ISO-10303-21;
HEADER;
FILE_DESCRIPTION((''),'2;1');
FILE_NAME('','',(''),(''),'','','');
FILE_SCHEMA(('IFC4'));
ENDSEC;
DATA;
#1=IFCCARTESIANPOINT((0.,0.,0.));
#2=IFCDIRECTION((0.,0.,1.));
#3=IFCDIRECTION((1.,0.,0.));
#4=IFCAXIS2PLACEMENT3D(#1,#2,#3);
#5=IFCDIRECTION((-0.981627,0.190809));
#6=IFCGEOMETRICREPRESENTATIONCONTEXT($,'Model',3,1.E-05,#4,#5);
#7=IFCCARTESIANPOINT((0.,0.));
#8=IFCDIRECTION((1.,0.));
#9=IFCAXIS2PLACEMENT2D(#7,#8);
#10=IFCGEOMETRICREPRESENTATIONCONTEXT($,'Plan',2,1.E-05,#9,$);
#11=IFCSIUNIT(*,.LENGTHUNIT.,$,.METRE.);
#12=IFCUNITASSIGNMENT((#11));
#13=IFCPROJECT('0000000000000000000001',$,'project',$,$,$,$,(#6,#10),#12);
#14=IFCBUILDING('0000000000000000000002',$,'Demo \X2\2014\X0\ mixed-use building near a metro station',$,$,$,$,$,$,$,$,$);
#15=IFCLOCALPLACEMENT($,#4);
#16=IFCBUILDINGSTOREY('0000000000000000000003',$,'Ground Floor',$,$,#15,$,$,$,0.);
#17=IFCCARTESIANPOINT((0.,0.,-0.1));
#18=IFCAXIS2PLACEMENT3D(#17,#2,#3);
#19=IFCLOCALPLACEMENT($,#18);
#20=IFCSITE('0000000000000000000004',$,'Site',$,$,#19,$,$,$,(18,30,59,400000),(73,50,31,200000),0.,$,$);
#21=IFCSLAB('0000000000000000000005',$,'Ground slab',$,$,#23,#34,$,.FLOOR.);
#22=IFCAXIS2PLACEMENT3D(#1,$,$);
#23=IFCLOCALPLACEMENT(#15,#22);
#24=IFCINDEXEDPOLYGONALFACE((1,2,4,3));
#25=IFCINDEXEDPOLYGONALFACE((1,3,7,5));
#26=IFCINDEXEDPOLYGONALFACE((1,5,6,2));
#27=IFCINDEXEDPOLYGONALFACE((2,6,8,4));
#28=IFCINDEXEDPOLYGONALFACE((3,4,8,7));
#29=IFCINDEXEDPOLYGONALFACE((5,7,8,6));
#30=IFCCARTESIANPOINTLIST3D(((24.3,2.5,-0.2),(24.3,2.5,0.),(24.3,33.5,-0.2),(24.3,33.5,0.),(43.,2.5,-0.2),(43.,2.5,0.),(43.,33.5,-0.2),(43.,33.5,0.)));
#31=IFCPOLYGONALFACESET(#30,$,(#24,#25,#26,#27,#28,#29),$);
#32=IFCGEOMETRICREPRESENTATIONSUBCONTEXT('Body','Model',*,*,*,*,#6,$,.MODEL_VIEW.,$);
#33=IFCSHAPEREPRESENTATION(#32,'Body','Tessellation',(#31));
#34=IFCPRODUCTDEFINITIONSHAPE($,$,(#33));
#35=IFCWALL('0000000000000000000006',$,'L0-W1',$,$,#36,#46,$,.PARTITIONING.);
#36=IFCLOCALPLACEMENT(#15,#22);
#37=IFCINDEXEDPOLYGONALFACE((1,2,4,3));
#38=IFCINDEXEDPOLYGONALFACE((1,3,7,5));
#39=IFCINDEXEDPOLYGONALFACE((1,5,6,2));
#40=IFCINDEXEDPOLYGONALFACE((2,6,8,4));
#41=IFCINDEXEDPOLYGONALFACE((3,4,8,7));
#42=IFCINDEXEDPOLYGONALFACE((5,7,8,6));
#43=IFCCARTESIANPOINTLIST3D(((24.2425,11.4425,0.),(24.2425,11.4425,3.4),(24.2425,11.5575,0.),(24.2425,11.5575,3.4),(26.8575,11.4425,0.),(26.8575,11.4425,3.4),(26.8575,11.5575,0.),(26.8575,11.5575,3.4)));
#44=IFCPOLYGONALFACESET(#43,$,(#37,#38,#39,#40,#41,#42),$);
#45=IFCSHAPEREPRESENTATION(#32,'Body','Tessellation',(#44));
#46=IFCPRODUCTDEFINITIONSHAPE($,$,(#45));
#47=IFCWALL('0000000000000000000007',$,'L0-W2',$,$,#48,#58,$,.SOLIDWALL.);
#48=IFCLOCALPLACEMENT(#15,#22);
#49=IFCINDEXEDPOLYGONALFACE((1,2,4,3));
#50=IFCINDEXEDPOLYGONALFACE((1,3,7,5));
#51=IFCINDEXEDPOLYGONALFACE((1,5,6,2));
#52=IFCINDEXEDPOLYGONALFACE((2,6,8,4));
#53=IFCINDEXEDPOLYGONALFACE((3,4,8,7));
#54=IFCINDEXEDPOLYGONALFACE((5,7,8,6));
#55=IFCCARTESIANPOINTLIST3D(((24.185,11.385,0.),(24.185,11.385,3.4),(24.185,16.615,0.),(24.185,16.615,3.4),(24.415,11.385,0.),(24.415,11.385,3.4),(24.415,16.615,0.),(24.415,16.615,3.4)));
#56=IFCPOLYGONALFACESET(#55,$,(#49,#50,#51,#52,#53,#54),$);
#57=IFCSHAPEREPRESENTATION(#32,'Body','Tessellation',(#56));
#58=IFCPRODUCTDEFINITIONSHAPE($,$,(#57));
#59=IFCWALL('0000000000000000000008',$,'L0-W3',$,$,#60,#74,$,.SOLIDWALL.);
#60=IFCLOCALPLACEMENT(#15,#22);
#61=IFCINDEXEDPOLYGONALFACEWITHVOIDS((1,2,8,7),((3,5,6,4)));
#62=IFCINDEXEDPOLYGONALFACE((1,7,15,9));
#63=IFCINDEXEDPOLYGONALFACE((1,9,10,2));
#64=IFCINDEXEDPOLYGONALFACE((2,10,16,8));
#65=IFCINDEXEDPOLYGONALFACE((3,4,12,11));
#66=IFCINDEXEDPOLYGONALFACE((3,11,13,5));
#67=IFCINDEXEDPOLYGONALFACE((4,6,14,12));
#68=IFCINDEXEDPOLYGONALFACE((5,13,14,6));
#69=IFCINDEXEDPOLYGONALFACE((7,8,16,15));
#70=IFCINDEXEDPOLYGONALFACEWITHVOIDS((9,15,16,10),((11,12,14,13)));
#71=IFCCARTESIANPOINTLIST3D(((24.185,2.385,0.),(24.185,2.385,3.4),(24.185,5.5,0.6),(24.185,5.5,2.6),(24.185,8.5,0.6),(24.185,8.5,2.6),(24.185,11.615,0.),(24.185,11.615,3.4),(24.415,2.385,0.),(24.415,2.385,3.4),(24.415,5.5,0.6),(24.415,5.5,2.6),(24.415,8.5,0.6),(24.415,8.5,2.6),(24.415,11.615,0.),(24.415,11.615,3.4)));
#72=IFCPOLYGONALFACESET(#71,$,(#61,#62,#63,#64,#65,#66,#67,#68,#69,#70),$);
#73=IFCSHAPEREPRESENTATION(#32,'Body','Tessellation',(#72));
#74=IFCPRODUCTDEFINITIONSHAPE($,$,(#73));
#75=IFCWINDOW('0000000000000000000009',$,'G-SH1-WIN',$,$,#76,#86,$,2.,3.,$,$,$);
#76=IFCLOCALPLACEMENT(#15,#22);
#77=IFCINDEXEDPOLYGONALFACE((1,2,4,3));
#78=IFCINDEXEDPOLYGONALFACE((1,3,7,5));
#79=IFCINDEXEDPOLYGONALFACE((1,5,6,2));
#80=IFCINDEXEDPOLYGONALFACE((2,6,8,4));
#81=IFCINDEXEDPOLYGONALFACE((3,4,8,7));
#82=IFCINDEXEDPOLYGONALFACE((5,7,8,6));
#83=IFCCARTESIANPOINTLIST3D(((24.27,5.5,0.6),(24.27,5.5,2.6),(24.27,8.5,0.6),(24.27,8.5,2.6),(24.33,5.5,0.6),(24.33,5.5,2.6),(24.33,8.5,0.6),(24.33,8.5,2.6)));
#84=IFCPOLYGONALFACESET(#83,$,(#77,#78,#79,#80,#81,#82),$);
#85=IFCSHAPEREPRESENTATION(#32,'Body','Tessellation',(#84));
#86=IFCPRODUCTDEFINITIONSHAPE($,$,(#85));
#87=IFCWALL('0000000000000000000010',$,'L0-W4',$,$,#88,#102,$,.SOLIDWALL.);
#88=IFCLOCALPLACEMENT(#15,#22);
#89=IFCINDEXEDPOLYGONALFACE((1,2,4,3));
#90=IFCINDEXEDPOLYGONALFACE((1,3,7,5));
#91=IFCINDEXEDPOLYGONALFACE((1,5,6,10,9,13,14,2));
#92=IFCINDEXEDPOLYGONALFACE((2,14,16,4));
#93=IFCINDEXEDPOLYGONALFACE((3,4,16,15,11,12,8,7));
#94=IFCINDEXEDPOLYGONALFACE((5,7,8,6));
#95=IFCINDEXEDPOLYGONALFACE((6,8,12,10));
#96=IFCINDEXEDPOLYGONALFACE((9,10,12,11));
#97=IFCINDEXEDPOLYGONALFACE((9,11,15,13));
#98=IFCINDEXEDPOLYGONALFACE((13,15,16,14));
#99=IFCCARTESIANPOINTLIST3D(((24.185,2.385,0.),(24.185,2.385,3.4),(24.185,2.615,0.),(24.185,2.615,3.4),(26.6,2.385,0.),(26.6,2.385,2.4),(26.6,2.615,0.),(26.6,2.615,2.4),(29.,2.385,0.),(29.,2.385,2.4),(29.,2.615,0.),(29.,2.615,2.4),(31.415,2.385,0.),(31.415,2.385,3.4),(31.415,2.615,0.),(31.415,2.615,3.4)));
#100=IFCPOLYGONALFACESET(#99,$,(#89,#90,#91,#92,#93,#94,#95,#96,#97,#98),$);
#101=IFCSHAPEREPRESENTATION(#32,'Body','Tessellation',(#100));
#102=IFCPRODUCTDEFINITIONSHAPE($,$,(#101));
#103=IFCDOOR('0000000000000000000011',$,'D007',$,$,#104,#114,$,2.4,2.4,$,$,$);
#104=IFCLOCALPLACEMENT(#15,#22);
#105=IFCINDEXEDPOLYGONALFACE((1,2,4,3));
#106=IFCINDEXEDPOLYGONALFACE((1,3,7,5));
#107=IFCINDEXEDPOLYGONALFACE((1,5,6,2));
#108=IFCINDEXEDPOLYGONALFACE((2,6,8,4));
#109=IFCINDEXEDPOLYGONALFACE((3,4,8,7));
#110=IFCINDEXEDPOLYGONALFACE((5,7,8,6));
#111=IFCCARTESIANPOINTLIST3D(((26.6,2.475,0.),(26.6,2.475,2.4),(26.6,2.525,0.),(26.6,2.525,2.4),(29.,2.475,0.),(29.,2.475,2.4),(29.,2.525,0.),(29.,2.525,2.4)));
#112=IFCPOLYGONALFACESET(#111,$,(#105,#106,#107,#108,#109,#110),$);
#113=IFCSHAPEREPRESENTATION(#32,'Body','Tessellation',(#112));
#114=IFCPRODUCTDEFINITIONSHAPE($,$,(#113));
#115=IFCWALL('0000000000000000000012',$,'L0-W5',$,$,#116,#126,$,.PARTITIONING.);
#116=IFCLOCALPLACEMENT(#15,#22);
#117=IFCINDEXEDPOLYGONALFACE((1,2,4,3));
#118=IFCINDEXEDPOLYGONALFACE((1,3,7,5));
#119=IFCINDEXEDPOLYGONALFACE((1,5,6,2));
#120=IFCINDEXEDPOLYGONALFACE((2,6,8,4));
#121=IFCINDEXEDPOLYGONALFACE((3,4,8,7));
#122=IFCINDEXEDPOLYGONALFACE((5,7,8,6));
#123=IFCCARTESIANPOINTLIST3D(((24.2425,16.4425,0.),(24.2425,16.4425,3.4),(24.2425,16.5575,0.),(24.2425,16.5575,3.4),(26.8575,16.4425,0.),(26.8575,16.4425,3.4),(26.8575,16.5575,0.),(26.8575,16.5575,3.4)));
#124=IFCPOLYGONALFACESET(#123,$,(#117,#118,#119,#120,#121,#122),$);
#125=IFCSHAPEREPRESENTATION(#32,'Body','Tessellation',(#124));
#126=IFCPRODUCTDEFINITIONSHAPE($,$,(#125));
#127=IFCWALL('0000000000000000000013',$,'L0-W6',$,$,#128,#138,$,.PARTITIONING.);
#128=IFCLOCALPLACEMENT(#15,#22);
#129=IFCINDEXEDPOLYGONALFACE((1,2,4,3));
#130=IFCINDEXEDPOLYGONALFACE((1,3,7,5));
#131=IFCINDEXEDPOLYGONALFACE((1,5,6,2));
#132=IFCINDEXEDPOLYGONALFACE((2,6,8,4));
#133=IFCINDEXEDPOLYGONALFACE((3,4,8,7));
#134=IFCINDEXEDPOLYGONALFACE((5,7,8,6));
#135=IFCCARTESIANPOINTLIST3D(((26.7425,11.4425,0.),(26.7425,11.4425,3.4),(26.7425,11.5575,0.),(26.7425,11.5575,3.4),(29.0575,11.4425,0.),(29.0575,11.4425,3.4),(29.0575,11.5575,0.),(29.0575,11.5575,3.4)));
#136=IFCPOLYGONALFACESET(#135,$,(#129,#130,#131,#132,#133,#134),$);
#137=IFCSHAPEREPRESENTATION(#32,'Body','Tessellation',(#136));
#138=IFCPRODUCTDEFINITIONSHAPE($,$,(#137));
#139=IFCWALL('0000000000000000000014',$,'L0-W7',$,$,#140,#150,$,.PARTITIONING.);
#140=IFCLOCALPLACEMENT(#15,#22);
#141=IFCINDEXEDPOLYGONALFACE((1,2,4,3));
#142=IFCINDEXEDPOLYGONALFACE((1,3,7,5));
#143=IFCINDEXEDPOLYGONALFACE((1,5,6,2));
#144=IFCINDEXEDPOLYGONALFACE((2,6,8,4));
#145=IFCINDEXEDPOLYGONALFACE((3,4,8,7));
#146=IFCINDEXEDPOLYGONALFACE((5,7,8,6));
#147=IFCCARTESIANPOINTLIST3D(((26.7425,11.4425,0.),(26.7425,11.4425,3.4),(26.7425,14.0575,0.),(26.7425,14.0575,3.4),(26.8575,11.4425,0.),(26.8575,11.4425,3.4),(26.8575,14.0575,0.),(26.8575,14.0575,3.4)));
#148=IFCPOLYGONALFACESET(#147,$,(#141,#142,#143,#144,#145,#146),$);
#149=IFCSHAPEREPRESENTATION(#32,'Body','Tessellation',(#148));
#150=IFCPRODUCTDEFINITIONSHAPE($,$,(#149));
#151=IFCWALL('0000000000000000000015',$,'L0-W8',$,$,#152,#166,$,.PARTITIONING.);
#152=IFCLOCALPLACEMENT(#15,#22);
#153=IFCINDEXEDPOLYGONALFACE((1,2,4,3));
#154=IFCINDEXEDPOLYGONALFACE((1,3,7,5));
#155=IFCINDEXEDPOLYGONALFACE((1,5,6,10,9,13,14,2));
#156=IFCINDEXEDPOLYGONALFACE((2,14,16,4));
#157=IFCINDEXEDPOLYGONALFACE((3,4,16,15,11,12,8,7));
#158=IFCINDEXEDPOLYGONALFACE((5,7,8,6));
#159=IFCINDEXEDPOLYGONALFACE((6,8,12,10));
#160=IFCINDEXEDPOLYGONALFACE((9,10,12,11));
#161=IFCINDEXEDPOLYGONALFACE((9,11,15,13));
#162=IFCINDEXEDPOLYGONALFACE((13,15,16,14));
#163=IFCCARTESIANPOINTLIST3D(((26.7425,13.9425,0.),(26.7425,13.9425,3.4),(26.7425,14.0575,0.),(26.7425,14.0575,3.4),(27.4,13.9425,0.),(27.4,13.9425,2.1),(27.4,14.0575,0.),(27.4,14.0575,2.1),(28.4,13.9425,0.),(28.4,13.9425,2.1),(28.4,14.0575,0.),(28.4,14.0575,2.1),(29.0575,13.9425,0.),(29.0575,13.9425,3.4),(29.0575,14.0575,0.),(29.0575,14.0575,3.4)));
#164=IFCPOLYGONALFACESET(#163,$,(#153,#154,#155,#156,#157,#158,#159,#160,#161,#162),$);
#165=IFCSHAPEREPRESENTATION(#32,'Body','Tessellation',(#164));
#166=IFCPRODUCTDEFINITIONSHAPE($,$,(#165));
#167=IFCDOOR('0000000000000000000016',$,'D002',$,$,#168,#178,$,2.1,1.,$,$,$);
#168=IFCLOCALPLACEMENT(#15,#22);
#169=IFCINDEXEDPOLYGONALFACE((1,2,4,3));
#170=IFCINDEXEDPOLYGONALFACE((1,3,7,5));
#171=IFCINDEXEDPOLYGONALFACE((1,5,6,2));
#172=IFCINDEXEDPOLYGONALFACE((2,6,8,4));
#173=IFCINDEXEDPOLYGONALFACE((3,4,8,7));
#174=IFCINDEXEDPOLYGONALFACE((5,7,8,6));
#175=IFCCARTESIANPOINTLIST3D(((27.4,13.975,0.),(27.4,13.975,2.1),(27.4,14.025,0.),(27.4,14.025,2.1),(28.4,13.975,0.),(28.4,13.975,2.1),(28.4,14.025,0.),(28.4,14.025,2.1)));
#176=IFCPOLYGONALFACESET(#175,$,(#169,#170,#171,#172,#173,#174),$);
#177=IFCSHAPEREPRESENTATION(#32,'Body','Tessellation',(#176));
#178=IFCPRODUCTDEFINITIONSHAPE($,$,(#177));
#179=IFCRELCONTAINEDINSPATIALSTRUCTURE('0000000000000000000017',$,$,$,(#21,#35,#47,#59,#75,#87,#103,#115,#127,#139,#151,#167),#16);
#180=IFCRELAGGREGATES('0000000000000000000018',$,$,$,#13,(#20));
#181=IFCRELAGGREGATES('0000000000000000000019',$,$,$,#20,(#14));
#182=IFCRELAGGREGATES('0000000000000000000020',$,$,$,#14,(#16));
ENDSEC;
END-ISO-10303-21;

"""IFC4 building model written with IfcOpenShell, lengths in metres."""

from ifc_helpers import new_model, si_unit, direction, frame, origin_with_axes, origin_2d_with_axis, place, context, subcontext, project, spatial, line, indexed_curve, outline, extrude, element, fill, save


model = new_model("IFC4")

# Units and contexts
model_context = context("Model", 3, precision=1e-05, world=origin_with_axes(), true_north=direction((-0.981627, 0.190809)))
plan_context = context("Plan", 2, precision=1e-05, world=origin_2d_with_axis())
body_context = subcontext(model_context, "Body", "Model", "MODEL_VIEW")
ifc_project = project(units=[si_unit("LENGTHUNIT", "METRE")], contexts=[model_context, plan_context])

# Site, building, storey
site_placement = place(None, frame((0.0, 0.0, -0.1), z_axis=(0.0, 0.0, 1.0), x_axis=(1.0, 0.0, 0.0)))
site = spatial("IfcSite", under=ifc_project, at=site_placement, Name="Site", RefLatitude=(18, 30, 59, 400000), RefLongitude=(73, 50, 31, 200000), RefElevation=0.0)
building = spatial("IfcBuilding", under=site, Name="Demo — mixed-use building near a metro station")
storey_placement = place(None, origin_with_axes())
storey = spatial("IfcBuildingStorey", under=building, at=storey_placement, Name="Ground Floor", Elevation=0.0)

# Slab
slab_placement = place(storey_placement, frame((0.0, 0.0, -0.2), z_axis=(0.0, 0.0, 1.0), x_axis=(1.0, 0.0, 0.0)))
element("IfcSlab", 1, at=slab_placement, inside=storey, Name="Ground slab", PredefinedType="FLOOR", context=body_context, shape_type="SweptSolid", body=[
    extrude(outline(indexed_curve([(24.3, 2.5), (43.0, 2.5), (43.0, 33.5), (24.3, 33.5)], segments=[line(1, 2, 3, 4, 1)])), origin_with_axes(), (0.0, 0.0, 1.0), 0.2),
])

# Walls
wall_1_placement = place(storey_placement, origin_with_axes())
element("IfcWall", 2, at=wall_1_placement, inside=storey, Name="L0-W1", PredefinedType="PARTITIONING", context=body_context, shape_type="SweptSolid", body=[
    extrude(outline(indexed_curve([(26.8575, 11.4425), (24.2425, 11.4425), (24.2425, 11.5575), (26.8575, 11.5575)], segments=[line(1, 2, 3, 4, 1)])), origin_with_axes(), (0.0, 0.0, 1.0), 3.4),
])
wall_2_placement = place(storey_placement, origin_with_axes())
element("IfcWall", 3, at=wall_2_placement, inside=storey, Name="L0-W2", PredefinedType="SOLIDWALL", context=body_context, shape_type="SweptSolid", body=[
    extrude(outline(indexed_curve([(24.415, 16.615), (24.415, 11.385), (24.185, 11.385), (24.185, 16.615)], segments=[line(1, 2, 3, 4, 1)])), origin_with_axes(), (0.0, 0.0, 1.0), 3.4),
])

# Wall, opening, window
wall_3_placement = place(storey_placement, origin_with_axes())
wall_3 = element("IfcWall", 4, at=wall_3_placement, inside=storey, Name="L0-W3", PredefinedType="SOLIDWALL", context=body_context, shape_type="SweptSolid", body=[
    extrude(outline(indexed_curve([(24.415, 11.615), (24.415, 2.385), (24.185, 2.385), (24.185, 11.615)], segments=[line(1, 2, 3, 4, 1)])), origin_with_axes(), (0.0, 0.0, 1.0), 3.4),
])
opening_1_placement = place(wall_3_placement, origin_with_axes())
opening_1 = element("IfcOpeningElement", 5, at=opening_1_placement, cuts=wall_3, context=body_context, shape_type="SweptSolid", body=[
    extrude(outline(indexed_curve([(24.465, 8.5), (24.465, 5.5), (24.135, 5.5), (24.135, 8.5)], segments=[line(1, 2, 3, 4, 1)])), frame((0.0, 0.0, 0.6), z_axis=(0.0, 0.0, 1.0), x_axis=(1.0, 0.0, 0.0)), (0.0, 0.0, 1.0), 2.0),
])
window_placement = place(storey_placement, origin_with_axes())
window = element("IfcWindow", 6, at=window_placement, inside=storey, Name="G-SH1-WIN", OverallHeight=2.0, OverallWidth=3.0, context=body_context, shape_type="SweptSolid", body=[
    extrude(outline(indexed_curve([(24.33, 8.5), (24.33, 5.5), (24.27, 5.5), (24.27, 8.5)], segments=[line(1, 2, 3, 4, 1)])), frame((0.0, 0.0, 0.6), z_axis=(0.0, 0.0, 1.0), x_axis=(1.0, 0.0, 0.0)), (0.0, 0.0, 1.0), 2.0),
])
fill(opening_1, window)

# Wall, opening, door
wall_4_placement = place(storey_placement, origin_with_axes())
wall_4 = element("IfcWall", 7, at=wall_4_placement, inside=storey, Name="L0-W4", PredefinedType="SOLIDWALL", context=body_context, shape_type="SweptSolid", body=[
    extrude(outline(indexed_curve([(24.185, 2.615), (31.415, 2.615), (31.415, 2.385), (24.185, 2.385)], segments=[line(1, 2, 3, 4, 1)])), origin_with_axes(), (0.0, 0.0, 1.0), 3.4),
])
opening_2_placement = place(wall_4_placement, origin_with_axes())
opening_2 = element("IfcOpeningElement", 8, at=opening_2_placement, cuts=wall_4, context=body_context, shape_type="SweptSolid", body=[
    extrude(outline(indexed_curve([(26.6, 2.665), (29.0, 2.665), (29.0, 2.335), (26.6, 2.335)], segments=[line(1, 2, 3, 4, 1)])), origin_with_axes(), (0.0, 0.0, 1.0), 2.4),
])
door_1_placement = place(storey_placement, origin_with_axes())
door_1 = element("IfcDoor", 9, at=door_1_placement, inside=storey, Name="D007", OverallHeight=2.4, OverallWidth=2.4, context=body_context, shape_type="SweptSolid", body=[
    extrude(outline(indexed_curve([(26.6, 2.525), (29.0, 2.525), (29.0, 2.475), (26.6, 2.475)], segments=[line(1, 2, 3, 4, 1)])), origin_with_axes(), (0.0, 0.0, 1.0), 2.4),
])
fill(opening_2, door_1)

# Walls
wall_5_placement = place(storey_placement, origin_with_axes())
element("IfcWall", 10, at=wall_5_placement, inside=storey, Name="L0-W5", PredefinedType="PARTITIONING", context=body_context, shape_type="SweptSolid", body=[
    extrude(outline(indexed_curve([(26.8575, 16.4425), (24.2425, 16.4425), (24.2425, 16.5575), (26.8575, 16.5575)], segments=[line(1, 2, 3, 4, 1)])), origin_with_axes(), (0.0, 0.0, 1.0), 3.4),
])
wall_6_placement = place(storey_placement, origin_with_axes())
element("IfcWall", 11, at=wall_6_placement, inside=storey, Name="L0-W6", PredefinedType="PARTITIONING", context=body_context, shape_type="SweptSolid", body=[
    extrude(outline(indexed_curve([(29.0575, 11.4425), (26.7425, 11.4425), (26.7425, 11.5575), (29.0575, 11.5575)], segments=[line(1, 2, 3, 4, 1)])), origin_with_axes(), (0.0, 0.0, 1.0), 3.4),
])
wall_7_placement = place(storey_placement, origin_with_axes())
element("IfcWall", 12, at=wall_7_placement, inside=storey, Name="L0-W7", PredefinedType="PARTITIONING", context=body_context, shape_type="SweptSolid", body=[
    extrude(outline(indexed_curve([(26.7425, 11.4425), (26.7425, 14.0575), (26.8575, 14.0575), (26.8575, 11.4425)], segments=[line(1, 2, 3, 4, 1)])), origin_with_axes(), (0.0, 0.0, 1.0), 3.4),
])

# Wall, opening, door
wall_8_placement = place(storey_placement, origin_with_axes())
wall_8 = element("IfcWall", 13, at=wall_8_placement, inside=storey, Name="L0-W8", PredefinedType="PARTITIONING", context=body_context, shape_type="SweptSolid", body=[
    extrude(outline(indexed_curve([(29.0575, 13.9425), (26.7425, 13.9425), (26.7425, 14.0575), (29.0575, 14.0575)], segments=[line(1, 2, 3, 4, 1)])), origin_with_axes(), (0.0, 0.0, 1.0), 3.4),
])
opening_3_placement = place(wall_8_placement, origin_with_axes())
opening_3 = element("IfcOpeningElement", 14, at=opening_3_placement, cuts=wall_8, context=body_context, shape_type="SweptSolid", body=[
    extrude(outline(indexed_curve([(28.4, 13.8925), (27.4, 13.8925), (27.4, 14.1075), (28.4, 14.1075)], segments=[line(1, 2, 3, 4, 1)])), origin_with_axes(), (0.0, 0.0, 1.0), 2.1),
])
door_2_placement = place(storey_placement, origin_with_axes())
door_2 = element("IfcDoor", 15, at=door_2_placement, inside=storey, Name="D002", OverallHeight=2.1, OverallWidth=1.0, context=body_context, shape_type="SweptSolid", body=[
    extrude(outline(indexed_curve([(28.4, 13.975), (27.4, 13.975), (27.4, 14.025), (28.4, 14.025)], segments=[line(1, 2, 3, 4, 1)])), origin_with_axes(), (0.0, 0.0, 1.0), 2.1),
])
fill(opening_3, door_2)

save(model, "model.ifc")
